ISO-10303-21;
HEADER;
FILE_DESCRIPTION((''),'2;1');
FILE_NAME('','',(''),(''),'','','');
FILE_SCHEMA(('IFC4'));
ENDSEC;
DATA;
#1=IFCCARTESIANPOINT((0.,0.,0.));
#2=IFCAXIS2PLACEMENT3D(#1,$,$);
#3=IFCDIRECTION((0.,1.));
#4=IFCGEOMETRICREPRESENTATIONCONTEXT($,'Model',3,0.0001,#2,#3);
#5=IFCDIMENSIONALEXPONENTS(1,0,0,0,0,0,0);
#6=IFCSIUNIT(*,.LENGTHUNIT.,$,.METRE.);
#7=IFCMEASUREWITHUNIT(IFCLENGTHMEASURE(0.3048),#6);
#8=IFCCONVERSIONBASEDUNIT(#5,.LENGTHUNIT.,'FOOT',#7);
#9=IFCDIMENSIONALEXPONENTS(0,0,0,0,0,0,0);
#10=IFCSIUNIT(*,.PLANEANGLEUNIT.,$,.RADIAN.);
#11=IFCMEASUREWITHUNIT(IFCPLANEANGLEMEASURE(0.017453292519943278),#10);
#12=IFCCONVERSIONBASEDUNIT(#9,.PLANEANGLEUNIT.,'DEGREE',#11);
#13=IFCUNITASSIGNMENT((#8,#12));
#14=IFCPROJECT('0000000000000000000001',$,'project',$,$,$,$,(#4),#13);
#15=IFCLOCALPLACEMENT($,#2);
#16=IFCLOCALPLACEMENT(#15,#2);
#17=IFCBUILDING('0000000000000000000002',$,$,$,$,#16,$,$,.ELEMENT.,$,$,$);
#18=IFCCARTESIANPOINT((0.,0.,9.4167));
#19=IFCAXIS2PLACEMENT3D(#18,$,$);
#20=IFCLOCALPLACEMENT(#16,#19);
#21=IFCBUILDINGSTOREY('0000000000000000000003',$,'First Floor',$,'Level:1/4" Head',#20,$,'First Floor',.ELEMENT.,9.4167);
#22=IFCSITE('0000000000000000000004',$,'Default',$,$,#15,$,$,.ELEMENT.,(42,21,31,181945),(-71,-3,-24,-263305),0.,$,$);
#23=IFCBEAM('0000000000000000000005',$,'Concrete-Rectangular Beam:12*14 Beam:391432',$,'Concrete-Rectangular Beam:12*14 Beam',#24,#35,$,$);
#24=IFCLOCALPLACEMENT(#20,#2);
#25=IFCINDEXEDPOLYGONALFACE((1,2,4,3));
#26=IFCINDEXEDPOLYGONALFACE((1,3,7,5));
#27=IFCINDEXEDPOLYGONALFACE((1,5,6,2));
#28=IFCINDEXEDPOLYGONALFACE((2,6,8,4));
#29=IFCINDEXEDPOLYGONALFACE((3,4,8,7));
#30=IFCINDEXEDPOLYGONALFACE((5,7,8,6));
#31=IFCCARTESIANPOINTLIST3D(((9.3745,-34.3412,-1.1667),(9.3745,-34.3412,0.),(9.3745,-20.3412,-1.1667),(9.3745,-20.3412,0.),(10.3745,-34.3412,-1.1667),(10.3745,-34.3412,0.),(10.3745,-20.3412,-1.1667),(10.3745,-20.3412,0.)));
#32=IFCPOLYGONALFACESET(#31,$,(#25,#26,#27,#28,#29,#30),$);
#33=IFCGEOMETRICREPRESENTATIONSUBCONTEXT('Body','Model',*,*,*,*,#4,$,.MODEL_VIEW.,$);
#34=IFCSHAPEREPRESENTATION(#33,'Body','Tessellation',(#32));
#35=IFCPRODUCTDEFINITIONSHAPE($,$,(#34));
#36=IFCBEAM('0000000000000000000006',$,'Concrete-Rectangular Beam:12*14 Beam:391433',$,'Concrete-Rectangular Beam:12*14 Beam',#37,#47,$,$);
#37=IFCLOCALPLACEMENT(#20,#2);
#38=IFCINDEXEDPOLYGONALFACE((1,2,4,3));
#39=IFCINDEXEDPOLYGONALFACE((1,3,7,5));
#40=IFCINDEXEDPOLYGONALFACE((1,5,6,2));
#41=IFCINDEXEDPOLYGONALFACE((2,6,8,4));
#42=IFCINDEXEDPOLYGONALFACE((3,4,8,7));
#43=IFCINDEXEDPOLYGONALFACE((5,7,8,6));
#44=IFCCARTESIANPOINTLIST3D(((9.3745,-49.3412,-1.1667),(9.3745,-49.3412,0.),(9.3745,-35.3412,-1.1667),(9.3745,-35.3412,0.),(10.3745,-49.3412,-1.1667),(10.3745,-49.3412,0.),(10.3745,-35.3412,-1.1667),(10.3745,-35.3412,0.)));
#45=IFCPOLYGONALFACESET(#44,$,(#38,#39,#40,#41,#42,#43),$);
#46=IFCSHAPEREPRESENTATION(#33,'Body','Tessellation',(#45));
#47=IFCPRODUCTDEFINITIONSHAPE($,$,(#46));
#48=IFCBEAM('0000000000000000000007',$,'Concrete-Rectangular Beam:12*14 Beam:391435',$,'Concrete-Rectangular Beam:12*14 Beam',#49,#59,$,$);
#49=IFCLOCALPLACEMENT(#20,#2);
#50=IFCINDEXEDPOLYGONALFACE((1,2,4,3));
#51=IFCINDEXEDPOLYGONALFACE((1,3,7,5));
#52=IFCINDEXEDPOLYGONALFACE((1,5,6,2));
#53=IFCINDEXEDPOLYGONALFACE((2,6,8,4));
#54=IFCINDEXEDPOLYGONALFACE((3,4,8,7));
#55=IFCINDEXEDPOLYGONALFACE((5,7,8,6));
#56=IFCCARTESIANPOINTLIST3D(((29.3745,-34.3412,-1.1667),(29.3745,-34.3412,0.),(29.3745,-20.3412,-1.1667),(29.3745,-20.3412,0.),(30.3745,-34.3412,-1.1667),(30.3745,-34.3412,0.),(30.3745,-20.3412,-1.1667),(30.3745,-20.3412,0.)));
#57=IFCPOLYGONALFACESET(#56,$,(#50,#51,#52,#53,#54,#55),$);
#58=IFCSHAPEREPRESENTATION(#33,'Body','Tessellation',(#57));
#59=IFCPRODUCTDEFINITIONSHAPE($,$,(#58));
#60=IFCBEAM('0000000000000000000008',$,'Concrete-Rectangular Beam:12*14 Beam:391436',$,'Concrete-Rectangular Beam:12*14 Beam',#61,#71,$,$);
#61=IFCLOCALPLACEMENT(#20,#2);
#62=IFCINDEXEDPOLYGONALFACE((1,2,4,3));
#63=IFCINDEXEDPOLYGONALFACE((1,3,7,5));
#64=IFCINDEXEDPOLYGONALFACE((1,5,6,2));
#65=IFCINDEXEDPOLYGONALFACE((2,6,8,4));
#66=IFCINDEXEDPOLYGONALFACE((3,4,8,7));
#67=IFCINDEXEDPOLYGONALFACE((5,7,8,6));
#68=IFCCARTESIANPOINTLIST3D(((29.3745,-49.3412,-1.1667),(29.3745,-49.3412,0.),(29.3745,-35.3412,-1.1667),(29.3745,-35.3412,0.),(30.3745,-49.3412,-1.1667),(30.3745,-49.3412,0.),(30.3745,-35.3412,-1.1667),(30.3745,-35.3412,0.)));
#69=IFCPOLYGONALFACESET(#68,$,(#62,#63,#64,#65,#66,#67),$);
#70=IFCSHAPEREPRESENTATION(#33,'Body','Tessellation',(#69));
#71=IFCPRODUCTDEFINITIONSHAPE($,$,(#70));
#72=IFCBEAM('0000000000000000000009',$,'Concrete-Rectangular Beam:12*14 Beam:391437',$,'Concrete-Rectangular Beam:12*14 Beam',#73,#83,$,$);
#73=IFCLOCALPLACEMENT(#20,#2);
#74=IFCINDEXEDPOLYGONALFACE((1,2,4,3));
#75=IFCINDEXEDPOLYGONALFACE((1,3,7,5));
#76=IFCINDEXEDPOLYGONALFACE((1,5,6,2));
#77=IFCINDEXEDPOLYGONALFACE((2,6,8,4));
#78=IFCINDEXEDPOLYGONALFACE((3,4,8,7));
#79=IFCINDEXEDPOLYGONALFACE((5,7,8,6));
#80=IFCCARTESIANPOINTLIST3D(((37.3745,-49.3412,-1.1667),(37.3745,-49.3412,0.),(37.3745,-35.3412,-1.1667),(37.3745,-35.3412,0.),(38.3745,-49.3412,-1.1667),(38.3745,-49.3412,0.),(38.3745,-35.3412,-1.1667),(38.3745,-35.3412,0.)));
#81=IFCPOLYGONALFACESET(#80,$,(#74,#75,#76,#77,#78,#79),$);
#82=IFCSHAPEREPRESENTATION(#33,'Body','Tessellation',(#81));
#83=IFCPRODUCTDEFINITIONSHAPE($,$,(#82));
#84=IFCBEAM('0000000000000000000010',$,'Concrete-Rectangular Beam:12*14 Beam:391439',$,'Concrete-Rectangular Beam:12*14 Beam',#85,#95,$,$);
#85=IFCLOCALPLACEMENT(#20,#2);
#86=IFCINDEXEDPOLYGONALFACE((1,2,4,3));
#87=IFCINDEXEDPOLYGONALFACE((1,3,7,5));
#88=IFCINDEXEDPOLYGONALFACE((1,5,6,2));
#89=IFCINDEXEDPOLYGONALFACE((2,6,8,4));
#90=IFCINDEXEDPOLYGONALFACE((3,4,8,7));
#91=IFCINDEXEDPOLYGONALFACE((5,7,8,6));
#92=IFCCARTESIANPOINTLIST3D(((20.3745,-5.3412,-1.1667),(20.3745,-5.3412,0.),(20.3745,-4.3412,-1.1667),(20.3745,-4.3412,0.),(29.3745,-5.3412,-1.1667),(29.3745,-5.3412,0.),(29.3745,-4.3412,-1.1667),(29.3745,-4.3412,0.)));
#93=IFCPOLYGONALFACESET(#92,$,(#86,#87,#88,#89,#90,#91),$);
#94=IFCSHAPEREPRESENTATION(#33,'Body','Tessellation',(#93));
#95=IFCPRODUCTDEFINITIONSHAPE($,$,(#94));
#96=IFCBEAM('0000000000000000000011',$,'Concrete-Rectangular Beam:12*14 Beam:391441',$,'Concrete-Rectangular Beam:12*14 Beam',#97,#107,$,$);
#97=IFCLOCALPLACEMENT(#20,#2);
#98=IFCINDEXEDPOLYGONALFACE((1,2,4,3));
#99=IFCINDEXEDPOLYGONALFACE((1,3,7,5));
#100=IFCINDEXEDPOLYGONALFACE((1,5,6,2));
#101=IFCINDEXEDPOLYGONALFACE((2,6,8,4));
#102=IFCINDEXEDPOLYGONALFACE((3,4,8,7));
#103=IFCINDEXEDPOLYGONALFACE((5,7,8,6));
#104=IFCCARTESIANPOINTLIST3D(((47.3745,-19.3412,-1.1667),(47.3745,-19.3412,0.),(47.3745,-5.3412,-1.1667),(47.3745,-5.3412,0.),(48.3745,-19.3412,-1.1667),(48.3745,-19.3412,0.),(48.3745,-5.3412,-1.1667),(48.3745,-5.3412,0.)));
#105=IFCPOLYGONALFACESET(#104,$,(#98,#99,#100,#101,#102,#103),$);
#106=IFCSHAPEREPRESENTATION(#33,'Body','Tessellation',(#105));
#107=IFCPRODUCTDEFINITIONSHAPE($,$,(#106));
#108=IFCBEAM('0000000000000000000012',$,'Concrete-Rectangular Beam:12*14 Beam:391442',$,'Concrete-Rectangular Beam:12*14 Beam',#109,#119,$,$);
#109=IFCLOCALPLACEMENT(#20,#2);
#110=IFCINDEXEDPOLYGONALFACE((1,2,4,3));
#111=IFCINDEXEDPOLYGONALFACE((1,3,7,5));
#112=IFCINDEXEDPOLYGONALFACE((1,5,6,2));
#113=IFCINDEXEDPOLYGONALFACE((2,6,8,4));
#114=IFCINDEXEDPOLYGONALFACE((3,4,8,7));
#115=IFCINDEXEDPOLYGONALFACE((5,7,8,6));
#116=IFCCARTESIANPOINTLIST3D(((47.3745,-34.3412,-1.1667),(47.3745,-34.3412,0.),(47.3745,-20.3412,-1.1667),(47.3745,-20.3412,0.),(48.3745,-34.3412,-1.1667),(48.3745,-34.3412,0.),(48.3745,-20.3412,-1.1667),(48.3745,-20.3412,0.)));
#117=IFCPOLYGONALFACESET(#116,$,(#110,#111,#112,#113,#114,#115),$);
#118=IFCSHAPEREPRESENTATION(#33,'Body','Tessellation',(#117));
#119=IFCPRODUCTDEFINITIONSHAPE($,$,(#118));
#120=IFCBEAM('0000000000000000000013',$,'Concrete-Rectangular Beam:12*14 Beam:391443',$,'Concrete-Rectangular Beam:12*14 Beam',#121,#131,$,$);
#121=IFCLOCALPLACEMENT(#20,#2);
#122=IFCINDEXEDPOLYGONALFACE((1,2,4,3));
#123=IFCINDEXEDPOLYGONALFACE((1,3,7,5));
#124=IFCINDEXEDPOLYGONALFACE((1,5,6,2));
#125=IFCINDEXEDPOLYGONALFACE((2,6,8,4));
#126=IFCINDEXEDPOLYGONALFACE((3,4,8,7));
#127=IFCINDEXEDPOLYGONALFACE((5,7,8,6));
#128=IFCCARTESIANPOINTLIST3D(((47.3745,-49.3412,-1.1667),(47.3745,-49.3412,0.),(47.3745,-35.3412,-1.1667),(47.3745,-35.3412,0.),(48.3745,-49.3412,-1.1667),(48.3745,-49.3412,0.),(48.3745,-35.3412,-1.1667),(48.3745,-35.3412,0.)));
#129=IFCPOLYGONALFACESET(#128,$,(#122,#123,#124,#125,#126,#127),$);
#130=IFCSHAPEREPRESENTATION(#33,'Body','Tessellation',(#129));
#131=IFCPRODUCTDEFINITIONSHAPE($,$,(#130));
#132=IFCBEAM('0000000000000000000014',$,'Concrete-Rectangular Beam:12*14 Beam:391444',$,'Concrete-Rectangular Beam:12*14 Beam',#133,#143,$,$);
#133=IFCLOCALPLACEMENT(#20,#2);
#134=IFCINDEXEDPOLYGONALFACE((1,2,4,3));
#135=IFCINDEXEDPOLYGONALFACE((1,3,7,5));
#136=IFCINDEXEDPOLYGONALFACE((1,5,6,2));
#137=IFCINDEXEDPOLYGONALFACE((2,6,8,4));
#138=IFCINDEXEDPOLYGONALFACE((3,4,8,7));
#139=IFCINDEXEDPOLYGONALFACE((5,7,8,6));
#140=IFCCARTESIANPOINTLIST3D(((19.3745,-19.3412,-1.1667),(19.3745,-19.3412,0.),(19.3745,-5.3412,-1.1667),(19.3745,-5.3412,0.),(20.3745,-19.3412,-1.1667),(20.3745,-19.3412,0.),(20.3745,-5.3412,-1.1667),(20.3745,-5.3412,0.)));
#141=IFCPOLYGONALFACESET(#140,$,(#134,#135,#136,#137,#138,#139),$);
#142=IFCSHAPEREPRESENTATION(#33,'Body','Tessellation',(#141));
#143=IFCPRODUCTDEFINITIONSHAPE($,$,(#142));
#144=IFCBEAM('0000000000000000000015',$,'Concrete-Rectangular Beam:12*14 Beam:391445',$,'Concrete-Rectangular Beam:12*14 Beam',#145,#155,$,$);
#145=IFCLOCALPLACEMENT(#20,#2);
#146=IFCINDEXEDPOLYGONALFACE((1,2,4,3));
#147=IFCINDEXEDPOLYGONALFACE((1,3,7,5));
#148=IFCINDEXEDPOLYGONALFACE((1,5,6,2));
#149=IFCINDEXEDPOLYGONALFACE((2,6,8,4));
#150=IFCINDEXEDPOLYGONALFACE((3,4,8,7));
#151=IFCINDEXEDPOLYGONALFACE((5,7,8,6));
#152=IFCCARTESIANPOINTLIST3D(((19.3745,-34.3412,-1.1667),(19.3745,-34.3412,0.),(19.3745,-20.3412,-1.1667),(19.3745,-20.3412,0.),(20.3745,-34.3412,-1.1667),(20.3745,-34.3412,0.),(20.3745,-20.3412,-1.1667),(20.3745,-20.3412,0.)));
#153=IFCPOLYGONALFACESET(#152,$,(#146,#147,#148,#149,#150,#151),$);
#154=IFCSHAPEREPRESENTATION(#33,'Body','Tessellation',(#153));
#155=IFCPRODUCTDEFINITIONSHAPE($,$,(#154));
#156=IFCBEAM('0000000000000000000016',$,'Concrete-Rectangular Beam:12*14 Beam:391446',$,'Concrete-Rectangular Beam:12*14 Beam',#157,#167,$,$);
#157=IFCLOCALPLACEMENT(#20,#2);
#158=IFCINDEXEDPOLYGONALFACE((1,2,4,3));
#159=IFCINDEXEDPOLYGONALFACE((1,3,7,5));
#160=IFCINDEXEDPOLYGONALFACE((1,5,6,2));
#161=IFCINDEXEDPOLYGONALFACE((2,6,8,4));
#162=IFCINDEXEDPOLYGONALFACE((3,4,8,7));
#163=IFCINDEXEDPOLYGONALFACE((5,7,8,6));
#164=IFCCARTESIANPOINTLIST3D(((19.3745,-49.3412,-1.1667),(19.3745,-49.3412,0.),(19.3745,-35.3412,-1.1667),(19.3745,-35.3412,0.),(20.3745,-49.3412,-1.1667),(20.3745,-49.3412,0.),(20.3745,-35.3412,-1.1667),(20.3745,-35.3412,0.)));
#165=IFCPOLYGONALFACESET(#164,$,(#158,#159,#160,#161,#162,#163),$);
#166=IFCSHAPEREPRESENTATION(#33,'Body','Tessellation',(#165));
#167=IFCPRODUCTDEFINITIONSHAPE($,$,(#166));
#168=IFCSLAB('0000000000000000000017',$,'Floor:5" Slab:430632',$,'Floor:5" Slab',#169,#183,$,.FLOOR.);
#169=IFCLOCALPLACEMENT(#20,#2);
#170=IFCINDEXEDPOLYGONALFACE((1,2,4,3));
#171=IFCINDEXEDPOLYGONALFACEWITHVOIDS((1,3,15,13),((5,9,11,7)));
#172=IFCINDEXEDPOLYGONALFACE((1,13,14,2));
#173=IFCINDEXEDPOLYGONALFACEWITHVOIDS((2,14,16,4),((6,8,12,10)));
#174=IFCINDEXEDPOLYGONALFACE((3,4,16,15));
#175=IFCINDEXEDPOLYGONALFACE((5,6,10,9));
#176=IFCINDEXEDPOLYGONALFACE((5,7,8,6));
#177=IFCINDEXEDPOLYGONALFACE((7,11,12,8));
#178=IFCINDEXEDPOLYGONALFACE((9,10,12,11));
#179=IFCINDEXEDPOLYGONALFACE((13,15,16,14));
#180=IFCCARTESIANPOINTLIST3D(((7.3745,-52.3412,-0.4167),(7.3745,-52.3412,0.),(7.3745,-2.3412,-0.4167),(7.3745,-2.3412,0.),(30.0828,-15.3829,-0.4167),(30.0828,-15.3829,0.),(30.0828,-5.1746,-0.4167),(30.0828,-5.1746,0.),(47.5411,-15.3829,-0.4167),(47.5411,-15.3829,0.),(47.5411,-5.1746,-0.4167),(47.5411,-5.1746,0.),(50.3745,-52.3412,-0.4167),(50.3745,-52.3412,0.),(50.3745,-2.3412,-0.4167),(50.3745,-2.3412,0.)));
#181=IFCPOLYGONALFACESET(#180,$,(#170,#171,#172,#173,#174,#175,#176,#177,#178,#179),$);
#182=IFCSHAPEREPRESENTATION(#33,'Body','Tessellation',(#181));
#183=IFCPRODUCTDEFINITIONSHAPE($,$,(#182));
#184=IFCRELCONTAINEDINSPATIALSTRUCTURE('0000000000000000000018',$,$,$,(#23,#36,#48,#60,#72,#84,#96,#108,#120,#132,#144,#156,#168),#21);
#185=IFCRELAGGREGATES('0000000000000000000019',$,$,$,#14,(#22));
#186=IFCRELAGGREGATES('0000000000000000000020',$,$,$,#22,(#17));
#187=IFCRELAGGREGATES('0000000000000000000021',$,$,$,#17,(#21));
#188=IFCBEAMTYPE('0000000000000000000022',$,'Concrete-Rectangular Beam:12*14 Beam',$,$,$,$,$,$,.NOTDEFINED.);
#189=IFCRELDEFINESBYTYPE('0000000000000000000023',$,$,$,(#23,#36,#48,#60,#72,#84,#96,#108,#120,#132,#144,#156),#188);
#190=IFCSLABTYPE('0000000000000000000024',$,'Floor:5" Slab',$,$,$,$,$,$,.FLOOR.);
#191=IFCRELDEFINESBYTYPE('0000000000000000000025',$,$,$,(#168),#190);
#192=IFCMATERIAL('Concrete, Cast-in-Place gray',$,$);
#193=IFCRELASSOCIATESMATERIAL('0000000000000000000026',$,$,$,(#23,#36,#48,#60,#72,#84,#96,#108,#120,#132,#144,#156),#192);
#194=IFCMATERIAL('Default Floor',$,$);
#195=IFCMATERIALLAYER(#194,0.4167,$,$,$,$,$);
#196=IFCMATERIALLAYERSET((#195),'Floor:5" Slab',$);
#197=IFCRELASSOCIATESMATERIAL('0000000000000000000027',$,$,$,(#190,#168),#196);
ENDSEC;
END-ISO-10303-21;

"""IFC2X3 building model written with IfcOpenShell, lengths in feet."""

from ifc_helpers import new_model, entity, si_unit, converted_unit, direction, frame, frame_2d, origin, place, context, subcontext, project, spatial, rectangle, extrude, material, layer, layer_set, layer_usage, type_object, element, save


model = new_model("IFC2X3")

# Units and contexts
model_context = context("Model", 3, precision=0.0001, world=origin(), true_north=direction((0.0, 1.0)))
body_context = subcontext(model_context, "Body", "Model", "MODEL_VIEW")
ifc_project = project(units=[converted_unit("LENGTHUNIT", "FOOT", entity("IfcLengthMeasure", 0.3048), si_unit("LENGTHUNIT", "METRE"), dimensions=[1, 0, 0, 0, 0, 0, 0]), converted_unit("PLANEANGLEUNIT", "DEGREE", entity("IfcPlaneAngleMeasure", 0.017453292519943278), si_unit("PLANEANGLEUNIT", "RADIAN"), dimensions=[0, 0, 0, 0, 0, 0, 0])], contexts=[model_context])

# Site, building, storey
site_placement = place(None, origin())
site = spatial("IfcSite", under=ifc_project, at=site_placement, Name="Default", CompositionType="ELEMENT", RefLatitude=(42, 21, 31, 181945), RefLongitude=(-71, -3, -24, -263305), RefElevation=0.0)
building_placement = place(site_placement, origin())
building = spatial("IfcBuilding", under=site, at=building_placement, CompositionType="ELEMENT")
storey_placement = place(building_placement, frame((0.0, 0.0, 9.4167)))
storey = spatial("IfcBuildingStorey", under=building, at=storey_placement, Name="First Floor", ObjectType="Level:1/4\" Head", LongName="First Floor", CompositionType="ELEMENT", Elevation=9.4167)

# Beams
ifc_material_1 = material(Name="Concrete, Cast-in-Place gray")
beam_type = type_object("IfcBeamType", Name="Concrete-Rectangular Beam:12*14 Beam", PredefinedType="NOTDEFINED")
beam_1_placement = place(storey_placement, frame((9.8745, -19.8412, 0.0), z_axis=(0.0, 0.0, 1.0), x_axis=(0.0, -1.0, 0.0)))
element("IfcBeam", 1, at=beam_1_placement, inside=storey, type_object=beam_type, material=ifc_material_1, Name="Concrete-Rectangular Beam:12*14 Beam:391432", ObjectType="Concrete-Rectangular Beam:12*14 Beam", context=body_context, shape_type="SweptSolid", body=[
    extrude(rectangle(XDim=1.1667, YDim=1.0, at=frame_2d((0.0, 0.0), x_axis=(1.0, 0.0))), frame((0.5, 0.0, -0.5833), z_axis=(1.0, 0.0, 0.0), x_axis=(0.0, 0.0, -1.0)), (0.0, 0.0, 1.0), 14.0),
])
beam_2_placement = place(storey_placement, frame((9.8745, -34.8412, 0.0), z_axis=(0.0, 0.0, 1.0), x_axis=(0.0, -1.0, 0.0)))
element("IfcBeam", 2, at=beam_2_placement, inside=storey, type_object=beam_type, material=ifc_material_1, Name="Concrete-Rectangular Beam:12*14 Beam:391433", ObjectType="Concrete-Rectangular Beam:12*14 Beam", context=body_context, shape_type="SweptSolid", body=[
    extrude(rectangle(XDim=1.1667, YDim=1.0, at=frame_2d((0.0, 0.0), x_axis=(1.0, 0.0))), frame((0.5, 0.0, -0.5833), z_axis=(1.0, 0.0, 0.0), x_axis=(0.0, 0.0, -1.0)), (0.0, 0.0, 1.0), 14.0),
])
beam_3_placement = place(storey_placement, frame((29.8745, -19.8412, 0.0), z_axis=(0.0, 0.0, 1.0), x_axis=(0.0, -1.0, 0.0)))
element("IfcBeam", 3, at=beam_3_placement, inside=storey, type_object=beam_type, material=ifc_material_1, Name="Concrete-Rectangular Beam:12*14 Beam:391435", ObjectType="Concrete-Rectangular Beam:12*14 Beam", context=body_context, shape_type="SweptSolid", body=[
    extrude(rectangle(XDim=1.1667, YDim=1.0, at=frame_2d((0.0, 0.0), x_axis=(1.0, 0.0))), frame((0.5, 0.0, -0.5833), z_axis=(1.0, 0.0, 0.0), x_axis=(0.0, 0.0, -1.0)), (0.0, 0.0, 1.0), 14.0),
])
beam_4_placement = place(storey_placement, frame((29.8745, -34.8412, 0.0), z_axis=(0.0, 0.0, 1.0), x_axis=(0.0, -1.0, 0.0)))
element("IfcBeam", 4, at=beam_4_placement, inside=storey, type_object=beam_type, material=ifc_material_1, Name="Concrete-Rectangular Beam:12*14 Beam:391436", ObjectType="Concrete-Rectangular Beam:12*14 Beam", context=body_context, shape_type="SweptSolid", body=[
    extrude(rectangle(XDim=1.1667, YDim=1.0, at=frame_2d((0.0, 0.0), x_axis=(1.0, 0.0))), frame((0.5, 0.0, -0.5833), z_axis=(1.0, 0.0, 0.0), x_axis=(0.0, 0.0, -1.0)), (0.0, 0.0, 1.0), 14.0),
])
beam_5_placement = place(storey_placement, frame((37.8745, -34.8412, 0.0), z_axis=(0.0, 0.0, 1.0), x_axis=(0.0, -1.0, 0.0)))
element("IfcBeam", 5, at=beam_5_placement, inside=storey, type_object=beam_type, material=ifc_material_1, Name="Concrete-Rectangular Beam:12*14 Beam:391437", ObjectType="Concrete-Rectangular Beam:12*14 Beam", context=body_context, shape_type="SweptSolid", body=[
    extrude(rectangle(XDim=1.1667, YDim=1.0, at=frame_2d((0.0, 0.0), x_axis=(1.0, 0.0))), frame((0.5, 0.0, -0.5833), z_axis=(1.0, 0.0, 0.0), x_axis=(0.0, 0.0, -1.0)), (0.0, 0.0, 1.0), 14.0),
])
beam_6_placement = place(storey_placement, frame((19.8745, -4.8412, 0.0)))
element("IfcBeam", 6, at=beam_6_placement, inside=storey, type_object=beam_type, material=ifc_material_1, Name="Concrete-Rectangular Beam:12*14 Beam:391439", ObjectType="Concrete-Rectangular Beam:12*14 Beam", context=body_context, shape_type="SweptSolid", body=[
    extrude(rectangle(XDim=1.1667, YDim=1.0, at=frame_2d((0.0, 0.0), x_axis=(1.0, 0.0))), frame((0.5, 0.0, -0.5833), z_axis=(1.0, 0.0, 0.0), x_axis=(0.0, 0.0, -1.0)), (0.0, 0.0, 1.0), 9.0),
])
beam_7_placement = place(storey_placement, frame((47.8745, -4.8412, 0.0), z_axis=(0.0, 0.0, 1.0), x_axis=(0.0, -1.0, 0.0)))
element("IfcBeam", 7, at=beam_7_placement, inside=storey, type_object=beam_type, material=ifc_material_1, Name="Concrete-Rectangular Beam:12*14 Beam:391441", ObjectType="Concrete-Rectangular Beam:12*14 Beam", context=body_context, shape_type="SweptSolid", body=[
    extrude(rectangle(XDim=1.1667, YDim=1.0, at=frame_2d((0.0, 0.0), x_axis=(1.0, 0.0))), frame((0.5, 0.0, -0.5833), z_axis=(1.0, 0.0, 0.0), x_axis=(0.0, 0.0, -1.0)), (0.0, 0.0, 1.0), 14.0),
])
beam_8_placement = place(storey_placement, frame((47.8745, -19.8412, 0.0), z_axis=(0.0, 0.0, 1.0), x_axis=(0.0, -1.0, 0.0)))
element("IfcBeam", 8, at=beam_8_placement, inside=storey, type_object=beam_type, material=ifc_material_1, Name="Concrete-Rectangular Beam:12*14 Beam:391442", ObjectType="Concrete-Rectangular Beam:12*14 Beam", context=body_context, shape_type="SweptSolid", body=[
    extrude(rectangle(XDim=1.1667, YDim=1.0, at=frame_2d((0.0, 0.0), x_axis=(1.0, 0.0))), frame((0.5, 0.0, -0.5833), z_axis=(1.0, 0.0, 0.0), x_axis=(0.0, 0.0, -1.0)), (0.0, 0.0, 1.0), 14.0),
])
beam_9_placement = place(storey_placement, frame((47.8745, -34.8412, 0.0), z_axis=(0.0, 0.0, 1.0), x_axis=(0.0, -1.0, 0.0)))
element("IfcBeam", 9, at=beam_9_placement, inside=storey, type_object=beam_type, material=ifc_material_1, Name="Concrete-Rectangular Beam:12*14 Beam:391443", ObjectType="Concrete-Rectangular Beam:12*14 Beam", context=body_context, shape_type="SweptSolid", body=[
    extrude(rectangle(XDim=1.1667, YDim=1.0, at=frame_2d((0.0, 0.0), x_axis=(1.0, 0.0))), frame((0.5, 0.0, -0.5833), z_axis=(1.0, 0.0, 0.0), x_axis=(0.0, 0.0, -1.0)), (0.0, 0.0, 1.0), 14.0),
])
beam_10_placement = place(storey_placement, frame((19.8745, -4.8412, 0.0), z_axis=(0.0, 0.0, 1.0), x_axis=(0.0, -1.0, 0.0)))
element("IfcBeam", 10, at=beam_10_placement, inside=storey, type_object=beam_type, material=ifc_material_1, Name="Concrete-Rectangular Beam:12*14 Beam:391444", ObjectType="Concrete-Rectangular Beam:12*14 Beam", context=body_context, shape_type="SweptSolid", body=[
    extrude(rectangle(XDim=1.1667, YDim=1.0, at=frame_2d((0.0, 0.0), x_axis=(1.0, 0.0))), frame((0.5, 0.0, -0.5833), z_axis=(1.0, 0.0, 0.0), x_axis=(0.0, 0.0, -1.0)), (0.0, 0.0, 1.0), 14.0),
])
beam_11_placement = place(storey_placement, frame((19.8745, -19.8412, 0.0), z_axis=(0.0, 0.0, 1.0), x_axis=(0.0, -1.0, 0.0)))
element("IfcBeam", 11, at=beam_11_placement, inside=storey, type_object=beam_type, material=ifc_material_1, Name="Concrete-Rectangular Beam:12*14 Beam:391445", ObjectType="Concrete-Rectangular Beam:12*14 Beam", context=body_context, shape_type="SweptSolid", body=[
    extrude(rectangle(XDim=1.1667, YDim=1.0, at=frame_2d((0.0, 0.0), x_axis=(1.0, 0.0))), frame((0.5, 0.0, -0.5833), z_axis=(1.0, 0.0, 0.0), x_axis=(0.0, 0.0, -1.0)), (0.0, 0.0, 1.0), 14.0),
])
beam_12_placement = place(storey_placement, frame((19.8745, -34.8412, 0.0), z_axis=(0.0, 0.0, 1.0), x_axis=(0.0, -1.0, 0.0)))
element("IfcBeam", 12, at=beam_12_placement, inside=storey, type_object=beam_type, material=ifc_material_1, Name="Concrete-Rectangular Beam:12*14 Beam:391446", ObjectType="Concrete-Rectangular Beam:12*14 Beam", context=body_context, shape_type="SweptSolid", body=[
    extrude(rectangle(XDim=1.1667, YDim=1.0, at=frame_2d((0.0, 0.0), x_axis=(1.0, 0.0))), frame((0.5, 0.0, -0.5833), z_axis=(1.0, 0.0, 0.0), x_axis=(0.0, 0.0, -1.0)), (0.0, 0.0, 1.0), 14.0),
])

# Slab, opening
ifc_material_2 = material(Name="Default Floor")
ifc_layer_1 = layer(ifc_material_2, 0.4167)
ifc_layer_set_1 = layer_set([ifc_layer_1], Name="Floor:5\" Slab")
ifc_layer_usage_1 = layer_usage(ifc_layer_set_1, "AXIS3", "POSITIVE", 0.0)
slab_type = type_object("IfcSlabType", Name="Floor:5\" Slab", PredefinedType="FLOOR", material=ifc_layer_set_1)
slab_placement = place(storey_placement, frame((7.3745, -52.3412, -0.4167)))
slab = element("IfcSlab", 13, at=slab_placement, inside=storey, type_object=slab_type, material=ifc_layer_usage_1, Name="Floor:5\" Slab:430632", ObjectType="Floor:5\" Slab", PredefinedType="FLOOR", context=body_context, shape_type="SweptSolid", body=[
    extrude(rectangle(XDim=50.0, YDim=43.0, at=frame_2d((0.0, 0.0), x_axis=(0.0, -1.0))), frame((21.5, 25.0, 0.4167), z_axis=(0.0, 0.0, -1.0), x_axis=(-1.0, 0.0, 0.0)), (0.0, 0.0, 1.0), 0.4167),
])
opening_placement = place(slab_placement, origin())
element("IfcOpeningElement", 14, at=opening_placement, cuts=slab, ObjectType="Opening", context=body_context, shape_type="SweptSolid", body=[
    extrude(rectangle(XDim=17.4583, YDim=10.2083, at=frame_2d((0.0, 0.0), x_axis=(1.0, 0.0))), frame((31.4375, 42.0625, 0.4167), z_axis=(0.0, 0.0, -1.0), x_axis=(1.0, 0.0, 0.0)), (0.0, 0.0, 1.0), 0.4167),
])

save(model, "model.ifc")
